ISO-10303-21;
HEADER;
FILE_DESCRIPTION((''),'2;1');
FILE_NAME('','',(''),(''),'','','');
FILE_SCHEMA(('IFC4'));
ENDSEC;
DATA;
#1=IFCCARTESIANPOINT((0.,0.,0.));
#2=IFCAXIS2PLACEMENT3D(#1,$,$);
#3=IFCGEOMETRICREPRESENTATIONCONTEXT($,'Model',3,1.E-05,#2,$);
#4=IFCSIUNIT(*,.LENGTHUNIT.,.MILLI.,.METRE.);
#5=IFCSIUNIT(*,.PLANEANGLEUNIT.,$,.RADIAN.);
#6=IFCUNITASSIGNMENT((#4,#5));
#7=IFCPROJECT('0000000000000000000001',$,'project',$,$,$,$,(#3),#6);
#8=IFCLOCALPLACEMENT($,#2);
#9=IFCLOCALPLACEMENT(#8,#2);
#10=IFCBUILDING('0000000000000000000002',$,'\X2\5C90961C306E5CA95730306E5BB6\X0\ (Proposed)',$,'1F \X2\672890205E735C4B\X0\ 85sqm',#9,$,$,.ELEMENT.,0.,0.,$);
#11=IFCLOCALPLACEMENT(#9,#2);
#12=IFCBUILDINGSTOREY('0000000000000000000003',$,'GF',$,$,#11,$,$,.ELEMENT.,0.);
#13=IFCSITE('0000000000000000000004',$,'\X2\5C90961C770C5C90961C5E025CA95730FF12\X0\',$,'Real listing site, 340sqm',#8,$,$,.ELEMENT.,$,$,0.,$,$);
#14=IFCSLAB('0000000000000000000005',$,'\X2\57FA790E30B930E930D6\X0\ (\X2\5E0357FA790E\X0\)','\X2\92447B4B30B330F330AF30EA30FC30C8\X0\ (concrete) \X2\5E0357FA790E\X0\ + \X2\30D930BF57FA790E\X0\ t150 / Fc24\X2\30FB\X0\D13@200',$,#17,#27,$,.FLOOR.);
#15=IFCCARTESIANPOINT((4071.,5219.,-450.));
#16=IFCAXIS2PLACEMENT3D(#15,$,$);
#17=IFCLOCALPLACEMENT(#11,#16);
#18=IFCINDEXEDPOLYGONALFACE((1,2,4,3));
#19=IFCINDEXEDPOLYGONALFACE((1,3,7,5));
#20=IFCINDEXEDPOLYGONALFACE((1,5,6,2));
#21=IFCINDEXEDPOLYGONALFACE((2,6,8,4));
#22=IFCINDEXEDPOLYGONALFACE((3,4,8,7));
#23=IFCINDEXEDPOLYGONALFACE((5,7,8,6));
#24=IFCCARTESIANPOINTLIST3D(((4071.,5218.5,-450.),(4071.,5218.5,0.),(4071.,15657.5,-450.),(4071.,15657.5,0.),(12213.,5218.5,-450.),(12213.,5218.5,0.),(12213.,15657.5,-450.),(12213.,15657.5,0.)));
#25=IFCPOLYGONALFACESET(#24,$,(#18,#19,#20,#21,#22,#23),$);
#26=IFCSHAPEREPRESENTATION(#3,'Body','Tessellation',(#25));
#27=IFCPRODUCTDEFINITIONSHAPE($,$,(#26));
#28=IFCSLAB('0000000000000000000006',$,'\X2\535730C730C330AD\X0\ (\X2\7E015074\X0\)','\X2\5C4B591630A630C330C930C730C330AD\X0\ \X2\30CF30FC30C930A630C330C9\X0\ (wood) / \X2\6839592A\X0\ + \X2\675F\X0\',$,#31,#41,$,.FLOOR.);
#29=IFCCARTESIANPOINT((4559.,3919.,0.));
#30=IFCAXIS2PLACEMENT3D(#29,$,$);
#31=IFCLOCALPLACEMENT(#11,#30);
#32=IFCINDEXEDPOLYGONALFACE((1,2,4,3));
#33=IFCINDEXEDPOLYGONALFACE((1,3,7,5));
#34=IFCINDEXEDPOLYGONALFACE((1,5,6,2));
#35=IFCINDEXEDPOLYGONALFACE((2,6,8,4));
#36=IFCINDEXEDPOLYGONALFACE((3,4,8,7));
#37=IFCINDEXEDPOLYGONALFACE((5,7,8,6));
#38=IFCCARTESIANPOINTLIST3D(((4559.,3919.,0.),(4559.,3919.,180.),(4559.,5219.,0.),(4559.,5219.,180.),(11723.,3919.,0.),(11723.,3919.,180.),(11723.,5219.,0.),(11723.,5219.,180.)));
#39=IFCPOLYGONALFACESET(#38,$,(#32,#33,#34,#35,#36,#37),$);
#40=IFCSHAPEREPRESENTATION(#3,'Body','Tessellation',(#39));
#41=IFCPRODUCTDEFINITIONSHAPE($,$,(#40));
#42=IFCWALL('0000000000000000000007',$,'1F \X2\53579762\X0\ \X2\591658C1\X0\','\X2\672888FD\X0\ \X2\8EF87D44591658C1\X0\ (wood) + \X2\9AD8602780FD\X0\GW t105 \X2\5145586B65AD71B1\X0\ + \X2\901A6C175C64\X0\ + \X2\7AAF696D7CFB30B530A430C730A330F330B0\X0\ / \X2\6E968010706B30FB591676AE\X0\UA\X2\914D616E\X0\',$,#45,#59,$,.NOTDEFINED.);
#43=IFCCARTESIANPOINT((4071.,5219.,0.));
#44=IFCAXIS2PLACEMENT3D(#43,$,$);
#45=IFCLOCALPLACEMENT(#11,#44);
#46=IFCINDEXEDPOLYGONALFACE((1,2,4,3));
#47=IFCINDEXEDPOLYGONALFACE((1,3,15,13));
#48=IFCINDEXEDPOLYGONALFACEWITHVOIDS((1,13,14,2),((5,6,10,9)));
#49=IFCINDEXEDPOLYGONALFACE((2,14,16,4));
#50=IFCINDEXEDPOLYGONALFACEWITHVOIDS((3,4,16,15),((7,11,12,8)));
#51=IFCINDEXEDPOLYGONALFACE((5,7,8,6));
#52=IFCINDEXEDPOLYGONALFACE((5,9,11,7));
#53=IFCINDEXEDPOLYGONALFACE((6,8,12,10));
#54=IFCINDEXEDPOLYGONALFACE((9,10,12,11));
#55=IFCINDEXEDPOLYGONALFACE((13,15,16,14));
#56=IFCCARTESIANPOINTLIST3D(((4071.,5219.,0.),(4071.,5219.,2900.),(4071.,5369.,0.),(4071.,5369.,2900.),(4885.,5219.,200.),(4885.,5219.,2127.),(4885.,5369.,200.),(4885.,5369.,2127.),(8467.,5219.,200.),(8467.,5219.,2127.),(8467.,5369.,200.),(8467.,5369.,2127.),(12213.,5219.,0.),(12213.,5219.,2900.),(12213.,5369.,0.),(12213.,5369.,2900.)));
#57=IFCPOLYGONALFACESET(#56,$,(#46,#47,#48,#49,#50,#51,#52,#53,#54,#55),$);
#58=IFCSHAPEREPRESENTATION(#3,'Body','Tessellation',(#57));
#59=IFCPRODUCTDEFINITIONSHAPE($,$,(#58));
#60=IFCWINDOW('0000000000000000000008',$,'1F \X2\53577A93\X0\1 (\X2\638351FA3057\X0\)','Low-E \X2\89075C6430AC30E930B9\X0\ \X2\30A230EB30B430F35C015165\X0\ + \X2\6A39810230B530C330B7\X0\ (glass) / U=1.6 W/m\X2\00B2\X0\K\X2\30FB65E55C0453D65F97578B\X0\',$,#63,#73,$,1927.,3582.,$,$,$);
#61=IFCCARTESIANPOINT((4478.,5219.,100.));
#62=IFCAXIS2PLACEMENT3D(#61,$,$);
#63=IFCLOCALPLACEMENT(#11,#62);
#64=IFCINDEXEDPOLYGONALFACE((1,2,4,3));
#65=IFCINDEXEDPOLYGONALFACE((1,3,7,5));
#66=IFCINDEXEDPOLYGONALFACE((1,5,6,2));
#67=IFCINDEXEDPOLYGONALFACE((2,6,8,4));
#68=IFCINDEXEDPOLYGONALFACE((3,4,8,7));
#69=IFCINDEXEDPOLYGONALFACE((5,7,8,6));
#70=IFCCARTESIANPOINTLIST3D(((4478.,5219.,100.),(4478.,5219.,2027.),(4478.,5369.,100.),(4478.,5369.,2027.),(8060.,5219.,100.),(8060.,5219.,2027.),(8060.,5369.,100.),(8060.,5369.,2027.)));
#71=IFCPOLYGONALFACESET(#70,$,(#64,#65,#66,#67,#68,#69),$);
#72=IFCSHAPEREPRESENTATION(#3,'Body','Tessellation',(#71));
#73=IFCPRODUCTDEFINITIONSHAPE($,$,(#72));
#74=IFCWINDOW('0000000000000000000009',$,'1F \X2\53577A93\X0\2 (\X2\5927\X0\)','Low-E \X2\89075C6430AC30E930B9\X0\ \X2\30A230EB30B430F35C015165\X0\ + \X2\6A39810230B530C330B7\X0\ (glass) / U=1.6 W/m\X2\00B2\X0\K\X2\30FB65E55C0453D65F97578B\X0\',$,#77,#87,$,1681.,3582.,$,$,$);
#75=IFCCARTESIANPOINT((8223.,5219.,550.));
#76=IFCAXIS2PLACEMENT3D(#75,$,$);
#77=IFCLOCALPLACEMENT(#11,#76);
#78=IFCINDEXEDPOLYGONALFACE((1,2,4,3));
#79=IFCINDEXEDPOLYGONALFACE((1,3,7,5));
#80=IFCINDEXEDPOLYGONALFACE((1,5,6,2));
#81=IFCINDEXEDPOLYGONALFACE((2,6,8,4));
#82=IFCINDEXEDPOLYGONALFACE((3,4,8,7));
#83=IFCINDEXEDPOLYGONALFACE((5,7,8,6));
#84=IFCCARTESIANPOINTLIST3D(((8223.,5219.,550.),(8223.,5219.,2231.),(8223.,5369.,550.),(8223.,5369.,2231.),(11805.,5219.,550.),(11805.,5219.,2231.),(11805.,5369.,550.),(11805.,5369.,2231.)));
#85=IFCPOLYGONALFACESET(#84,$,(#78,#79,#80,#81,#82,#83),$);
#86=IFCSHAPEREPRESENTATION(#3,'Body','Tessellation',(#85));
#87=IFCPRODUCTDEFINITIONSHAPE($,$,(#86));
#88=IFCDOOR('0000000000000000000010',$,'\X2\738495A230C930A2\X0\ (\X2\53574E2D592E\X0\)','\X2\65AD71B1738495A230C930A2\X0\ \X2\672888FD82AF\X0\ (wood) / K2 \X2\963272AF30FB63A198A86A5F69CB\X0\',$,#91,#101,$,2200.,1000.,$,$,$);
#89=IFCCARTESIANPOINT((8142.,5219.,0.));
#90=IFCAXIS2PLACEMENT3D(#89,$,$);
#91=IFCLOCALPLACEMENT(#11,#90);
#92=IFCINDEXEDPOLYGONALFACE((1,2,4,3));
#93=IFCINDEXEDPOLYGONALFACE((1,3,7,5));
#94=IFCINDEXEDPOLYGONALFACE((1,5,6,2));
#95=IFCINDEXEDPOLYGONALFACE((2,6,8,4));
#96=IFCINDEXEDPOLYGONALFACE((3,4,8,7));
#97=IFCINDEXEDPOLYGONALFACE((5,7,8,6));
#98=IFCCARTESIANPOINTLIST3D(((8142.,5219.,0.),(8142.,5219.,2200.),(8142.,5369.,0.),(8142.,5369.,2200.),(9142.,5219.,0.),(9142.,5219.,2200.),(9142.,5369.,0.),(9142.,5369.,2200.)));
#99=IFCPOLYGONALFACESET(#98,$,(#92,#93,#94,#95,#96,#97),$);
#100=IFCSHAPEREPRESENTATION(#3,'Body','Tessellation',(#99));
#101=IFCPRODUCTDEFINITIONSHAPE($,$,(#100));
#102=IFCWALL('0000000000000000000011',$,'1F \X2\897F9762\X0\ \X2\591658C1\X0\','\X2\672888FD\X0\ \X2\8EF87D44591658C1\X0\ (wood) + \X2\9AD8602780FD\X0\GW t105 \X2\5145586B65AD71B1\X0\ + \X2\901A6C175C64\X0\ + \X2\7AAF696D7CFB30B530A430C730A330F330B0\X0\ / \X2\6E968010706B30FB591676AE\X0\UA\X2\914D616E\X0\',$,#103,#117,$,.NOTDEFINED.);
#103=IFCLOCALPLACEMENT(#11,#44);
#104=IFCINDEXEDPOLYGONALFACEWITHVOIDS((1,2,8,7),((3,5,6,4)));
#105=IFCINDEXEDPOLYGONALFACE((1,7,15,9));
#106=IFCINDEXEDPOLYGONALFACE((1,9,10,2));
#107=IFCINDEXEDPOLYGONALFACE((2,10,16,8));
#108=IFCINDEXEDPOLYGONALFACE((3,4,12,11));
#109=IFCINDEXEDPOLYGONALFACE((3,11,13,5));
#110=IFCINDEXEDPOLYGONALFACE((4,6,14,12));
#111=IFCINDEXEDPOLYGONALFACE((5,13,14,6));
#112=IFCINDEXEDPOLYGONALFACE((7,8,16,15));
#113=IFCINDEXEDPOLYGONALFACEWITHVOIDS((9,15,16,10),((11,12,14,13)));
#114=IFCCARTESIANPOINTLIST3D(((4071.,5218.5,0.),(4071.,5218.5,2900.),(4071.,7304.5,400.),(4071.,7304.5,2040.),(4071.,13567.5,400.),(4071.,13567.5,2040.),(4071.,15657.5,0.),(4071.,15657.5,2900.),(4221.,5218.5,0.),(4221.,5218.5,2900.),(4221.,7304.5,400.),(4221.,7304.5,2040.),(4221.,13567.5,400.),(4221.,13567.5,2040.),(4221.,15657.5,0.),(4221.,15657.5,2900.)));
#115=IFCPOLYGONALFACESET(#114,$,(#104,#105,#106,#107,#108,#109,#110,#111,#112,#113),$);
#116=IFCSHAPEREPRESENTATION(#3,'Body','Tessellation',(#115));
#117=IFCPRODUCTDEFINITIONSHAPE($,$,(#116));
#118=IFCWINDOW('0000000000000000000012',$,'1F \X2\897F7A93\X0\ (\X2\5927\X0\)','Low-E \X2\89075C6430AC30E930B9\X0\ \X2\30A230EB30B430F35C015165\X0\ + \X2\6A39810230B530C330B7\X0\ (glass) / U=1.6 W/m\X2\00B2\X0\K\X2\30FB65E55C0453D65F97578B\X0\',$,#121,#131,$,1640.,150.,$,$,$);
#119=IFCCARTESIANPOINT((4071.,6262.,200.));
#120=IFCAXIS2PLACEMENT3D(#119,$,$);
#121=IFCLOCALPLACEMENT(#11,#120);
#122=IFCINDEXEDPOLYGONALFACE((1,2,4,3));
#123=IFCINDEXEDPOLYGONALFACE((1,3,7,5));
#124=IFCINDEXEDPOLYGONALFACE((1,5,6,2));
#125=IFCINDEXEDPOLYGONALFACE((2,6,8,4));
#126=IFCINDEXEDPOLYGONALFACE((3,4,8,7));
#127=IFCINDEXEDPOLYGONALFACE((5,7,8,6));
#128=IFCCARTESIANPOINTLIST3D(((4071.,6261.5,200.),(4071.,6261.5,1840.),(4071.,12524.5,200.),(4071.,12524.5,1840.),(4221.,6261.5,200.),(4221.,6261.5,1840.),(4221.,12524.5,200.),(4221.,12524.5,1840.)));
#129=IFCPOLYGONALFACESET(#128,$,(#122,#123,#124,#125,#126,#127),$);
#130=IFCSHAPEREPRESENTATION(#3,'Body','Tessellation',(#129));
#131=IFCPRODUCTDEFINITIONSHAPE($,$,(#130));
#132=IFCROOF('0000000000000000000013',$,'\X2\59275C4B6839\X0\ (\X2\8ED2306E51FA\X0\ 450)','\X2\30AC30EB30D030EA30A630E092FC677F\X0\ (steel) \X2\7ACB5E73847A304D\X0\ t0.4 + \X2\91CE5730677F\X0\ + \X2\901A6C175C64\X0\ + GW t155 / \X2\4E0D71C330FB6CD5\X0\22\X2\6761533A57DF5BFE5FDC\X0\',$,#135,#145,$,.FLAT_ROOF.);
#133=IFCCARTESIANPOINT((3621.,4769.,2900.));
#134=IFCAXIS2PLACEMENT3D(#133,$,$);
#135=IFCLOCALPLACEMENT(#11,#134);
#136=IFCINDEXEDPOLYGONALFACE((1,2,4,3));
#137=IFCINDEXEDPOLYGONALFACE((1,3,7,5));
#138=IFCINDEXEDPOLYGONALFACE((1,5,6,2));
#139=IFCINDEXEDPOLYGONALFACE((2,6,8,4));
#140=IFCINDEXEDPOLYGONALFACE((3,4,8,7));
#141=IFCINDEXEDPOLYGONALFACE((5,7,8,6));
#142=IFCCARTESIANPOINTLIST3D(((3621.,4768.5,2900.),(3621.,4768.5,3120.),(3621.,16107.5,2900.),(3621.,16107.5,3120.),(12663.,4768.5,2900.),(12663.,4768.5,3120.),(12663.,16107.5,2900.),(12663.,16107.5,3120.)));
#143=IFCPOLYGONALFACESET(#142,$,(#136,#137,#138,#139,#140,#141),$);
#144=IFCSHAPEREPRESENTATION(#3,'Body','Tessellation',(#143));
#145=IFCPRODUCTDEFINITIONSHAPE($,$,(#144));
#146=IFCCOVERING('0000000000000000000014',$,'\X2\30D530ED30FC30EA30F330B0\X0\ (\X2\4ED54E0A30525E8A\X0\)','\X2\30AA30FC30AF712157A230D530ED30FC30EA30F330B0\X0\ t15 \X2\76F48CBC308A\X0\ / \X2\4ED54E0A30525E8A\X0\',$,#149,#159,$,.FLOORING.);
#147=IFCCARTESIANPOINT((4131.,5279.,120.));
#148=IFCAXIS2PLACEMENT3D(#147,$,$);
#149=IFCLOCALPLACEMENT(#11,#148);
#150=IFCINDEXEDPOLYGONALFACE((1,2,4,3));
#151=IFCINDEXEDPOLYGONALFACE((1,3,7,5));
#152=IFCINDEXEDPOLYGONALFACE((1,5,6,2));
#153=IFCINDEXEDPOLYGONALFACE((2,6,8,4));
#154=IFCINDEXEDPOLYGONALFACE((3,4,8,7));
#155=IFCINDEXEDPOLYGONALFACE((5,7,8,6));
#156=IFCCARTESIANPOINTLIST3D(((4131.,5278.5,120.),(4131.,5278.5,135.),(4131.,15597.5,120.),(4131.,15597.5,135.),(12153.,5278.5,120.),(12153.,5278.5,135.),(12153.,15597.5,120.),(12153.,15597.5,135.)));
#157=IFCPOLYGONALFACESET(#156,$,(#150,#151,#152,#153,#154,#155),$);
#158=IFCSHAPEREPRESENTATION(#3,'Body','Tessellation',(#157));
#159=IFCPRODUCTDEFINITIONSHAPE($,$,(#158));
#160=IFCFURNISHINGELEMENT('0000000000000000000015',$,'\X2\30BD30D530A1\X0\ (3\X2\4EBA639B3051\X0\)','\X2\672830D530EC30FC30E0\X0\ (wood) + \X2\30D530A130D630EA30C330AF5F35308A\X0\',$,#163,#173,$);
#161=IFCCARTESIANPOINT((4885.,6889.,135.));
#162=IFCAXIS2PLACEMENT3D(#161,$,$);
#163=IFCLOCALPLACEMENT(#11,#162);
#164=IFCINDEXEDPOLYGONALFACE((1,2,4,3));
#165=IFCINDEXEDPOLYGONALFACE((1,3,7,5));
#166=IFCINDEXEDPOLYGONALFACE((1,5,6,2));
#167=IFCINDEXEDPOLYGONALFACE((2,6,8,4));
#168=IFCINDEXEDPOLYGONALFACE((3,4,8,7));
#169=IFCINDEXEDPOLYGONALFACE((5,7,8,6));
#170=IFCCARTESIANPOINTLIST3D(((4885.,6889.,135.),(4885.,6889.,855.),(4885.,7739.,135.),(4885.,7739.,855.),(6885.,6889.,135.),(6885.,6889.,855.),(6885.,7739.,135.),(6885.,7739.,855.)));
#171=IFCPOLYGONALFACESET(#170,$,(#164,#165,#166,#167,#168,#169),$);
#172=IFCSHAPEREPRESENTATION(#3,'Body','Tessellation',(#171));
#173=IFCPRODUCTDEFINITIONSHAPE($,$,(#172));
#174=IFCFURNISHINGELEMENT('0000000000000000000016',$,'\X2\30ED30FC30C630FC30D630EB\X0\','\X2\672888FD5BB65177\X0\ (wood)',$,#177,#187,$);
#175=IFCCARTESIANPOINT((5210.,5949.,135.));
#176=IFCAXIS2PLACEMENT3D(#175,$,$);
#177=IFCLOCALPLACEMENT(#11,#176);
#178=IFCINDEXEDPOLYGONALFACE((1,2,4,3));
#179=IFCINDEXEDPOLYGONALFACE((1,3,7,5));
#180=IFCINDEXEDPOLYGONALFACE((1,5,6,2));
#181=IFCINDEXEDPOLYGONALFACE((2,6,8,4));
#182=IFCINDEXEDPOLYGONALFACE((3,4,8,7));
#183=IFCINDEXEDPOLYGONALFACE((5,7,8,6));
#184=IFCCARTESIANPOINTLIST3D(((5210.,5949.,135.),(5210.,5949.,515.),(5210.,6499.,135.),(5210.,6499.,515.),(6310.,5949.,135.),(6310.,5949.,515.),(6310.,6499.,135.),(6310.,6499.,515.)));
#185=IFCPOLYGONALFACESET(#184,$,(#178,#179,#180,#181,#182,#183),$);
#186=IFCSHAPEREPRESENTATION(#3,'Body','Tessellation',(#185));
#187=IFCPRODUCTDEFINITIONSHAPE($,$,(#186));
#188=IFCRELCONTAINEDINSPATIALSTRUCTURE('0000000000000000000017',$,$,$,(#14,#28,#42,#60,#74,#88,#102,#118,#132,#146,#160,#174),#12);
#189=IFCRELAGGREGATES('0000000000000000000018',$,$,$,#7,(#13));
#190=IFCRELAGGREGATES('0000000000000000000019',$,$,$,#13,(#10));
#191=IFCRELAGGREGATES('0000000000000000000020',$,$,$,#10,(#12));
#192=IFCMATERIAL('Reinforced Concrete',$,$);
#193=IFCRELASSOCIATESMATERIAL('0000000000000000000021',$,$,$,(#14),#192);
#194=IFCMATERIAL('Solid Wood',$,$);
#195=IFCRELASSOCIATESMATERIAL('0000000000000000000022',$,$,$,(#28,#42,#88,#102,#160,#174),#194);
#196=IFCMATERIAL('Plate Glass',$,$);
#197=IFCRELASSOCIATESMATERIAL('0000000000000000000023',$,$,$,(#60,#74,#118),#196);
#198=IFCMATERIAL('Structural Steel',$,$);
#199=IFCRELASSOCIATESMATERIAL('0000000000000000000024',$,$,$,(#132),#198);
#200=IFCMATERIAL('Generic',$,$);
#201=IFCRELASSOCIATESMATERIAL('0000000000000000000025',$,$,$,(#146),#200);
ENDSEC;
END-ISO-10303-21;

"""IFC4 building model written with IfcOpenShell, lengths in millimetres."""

from ifc_helpers import new_model, si_unit, frame, frame_2d, origin, place, context, project, spatial, rectangle, extrude, material, element, fill, save


model = new_model("IFC4")

# Units and contexts
model_context = context("Model", 3, precision=1e-05, world=origin())
ifc_project = project(units=[si_unit("LENGTHUNIT", "METRE", prefix="MILLI"), si_unit("PLANEANGLEUNIT", "RADIAN")], contexts=[model_context])

# Site, building, storey
site_placement = place(None, origin())
site = spatial("IfcSite", under=ifc_project, at=site_placement, Name="岐阜県岐阜市岩地２", ObjectType="Real listing site, 340sqm", CompositionType="ELEMENT", RefElevation=0.0)
building_placement = place(site_placement, origin())
building = spatial("IfcBuilding", under=site, at=building_placement, Name="岐阜の岩地の家 (Proposed)", ObjectType="1F 木造平屋 85sqm", CompositionType="ELEMENT", ElevationOfRefHeight=0.0, ElevationOfTerrain=0.0)
storey_placement = place(building_placement, origin())
storey = spatial("IfcBuildingStorey", under=building, at=storey_placement, Name="GF", CompositionType="ELEMENT", Elevation=0.0)

# Slabs
ifc_material_1 = material(Name="Reinforced Concrete")
slab_1_placement = place(storey_placement, frame((4071.0, 5219.0, -450.0)))
element("IfcSlab", 1, at=slab_1_placement, inside=storey, material=ifc_material_1, Name="基礎スラブ (布基礎)", Description="鉄筋コンクリート (concrete) 布基礎 + ベタ基礎 t150 / Fc24・D13@200", PredefinedType="FLOOR", context=model_context, shape_type="SweptSolid", body=[
    extrude(rectangle(XDim=8142.0, YDim=10439.0, at=frame_2d((4071.0, 5219.0))), frame((4071.0, 5219.0, -450.0)), (0.0, 0.0, 1.0), 450.0),
])
ifc_material_2 = material(Name="Solid Wood")
slab_2_placement = place(storey_placement, frame((4559.0, 3919.0, 0.0)))
element("IfcSlab", 2, at=slab_2_placement, inside=storey, material=ifc_material_2, Name="南デッキ (縁側)", Description="屋外ウッドデッキ ハードウッド (wood) / 根太 + 束", PredefinedType="FLOOR", context=model_context, shape_type="SweptSolid", body=[
    extrude(rectangle(XDim=7164.0, YDim=1300.0, at=frame_2d((3582.0, 650.0))), frame((4559.0, 3919.0, 0.0)), (0.0, 0.0, 1.0), 180.0),
])

# Wall, openings, windows, door
wall_1_placement = place(storey_placement, frame((4071.0, 5219.0, 0.0)))
wall_1 = element("IfcWall", 3, at=wall_1_placement, inside=storey, material=ifc_material_2, Name="1F 南面 外壁", Description="木製 軸組外壁 (wood) + 高性能GW t105 充填断熱 + 通気層 + 窯業系サイディング / 準耐火・外皮UA配慮", PredefinedType="NOTDEFINED", context=model_context, shape_type="SweptSolid", body=[
    extrude(rectangle(XDim=8142.0, YDim=150.0, at=frame_2d((4071.0, 75.0))), frame((4071.0, 5219.0, 0.0)), (0.0, 0.0, 1.0), 2900.0),
])
opening_1_placement = place(storey_placement, frame((4478.0, 5219.0, 100.0)))
opening_1 = element("IfcOpeningElement", 4, at=opening_1_placement, cuts=wall_1, PredefinedType="NOTDEFINED", context=model_context, shape_type="SweptSolid", body=[
    extrude(rectangle(XDim=3582.0, YDim=150.0, at=frame_2d((1791.0, 75.0))), frame((4478.0, 5219.0, 100.0)), (0.0, 0.0, 1.0), 1927.0),
])
opening_2_placement = place(storey_placement, frame((8223.0, 5219.0, 550.0)))
opening_2 = element("IfcOpeningElement", 5, at=opening_2_placement, cuts=wall_1, PredefinedType="NOTDEFINED", context=model_context, shape_type="SweptSolid", body=[
    extrude(rectangle(XDim=3582.0, YDim=150.0, at=frame_2d((1791.0, 75.0))), frame((8223.0, 5219.0, 550.0)), (0.0, 0.0, 1.0), 1681.0),
])
opening_3_placement = place(storey_placement, frame((8142.0, 5219.0, 0.0)))
opening_3 = element("IfcOpeningElement", 6, at=opening_3_placement, cuts=wall_1, PredefinedType="NOTDEFINED", context=model_context, shape_type="SweptSolid", body=[
    extrude(rectangle(XDim=1000.0, YDim=150.0, at=frame_2d((500.0, 75.0))), frame((8142.0, 5219.0, 0.0)), (0.0, 0.0, 1.0), 2200.0),
])
ifc_material_3 = material(Name="Plate Glass")
window_1_placement = place(storey_placement, frame((4478.0, 5219.0, 100.0)))
window_1 = element("IfcWindow", 7, at=window_1_placement, inside=storey, material=ifc_material_3, Name="1F 南窓1 (掃出し)", Description="Low-E 複層ガラス アルゴン封入 + 樹脂サッシ (glass) / U=1.6 W/m²K・日射取得型", OverallHeight=1927.0, OverallWidth=3582.0, context=model_context, shape_type="SweptSolid", body=[
    extrude(rectangle(XDim=3582.0, YDim=150.0, at=frame_2d((1791.0, 75.0))), frame((4478.0, 5219.0, 100.0)), (0.0, 0.0, 1.0), 1927.0),
])
fill(opening_1, window_1)
window_2_placement = place(storey_placement, frame((8223.0, 5219.0, 550.0)))
window_2 = element("IfcWindow", 8, at=window_2_placement, inside=storey, material=ifc_material_3, Name="1F 南窓2 (大)", Description="Low-E 複層ガラス アルゴン封入 + 樹脂サッシ (glass) / U=1.6 W/m²K・日射取得型", OverallHeight=1681.0, OverallWidth=3582.0, context=model_context, shape_type="SweptSolid", body=[
    extrude(rectangle(XDim=3582.0, YDim=150.0, at=frame_2d((1791.0, 75.0))), frame((8223.0, 5219.0, 550.0)), (0.0, 0.0, 1.0), 1681.0),
])
fill(opening_2, window_2)
door_placement = place(storey_placement, frame((8142.0, 5219.0, 0.0)))
door = element("IfcDoor", 9, at=door_placement, inside=storey, material=ifc_material_2, Name="玄関ドア (南中央)", Description="断熱玄関ドア 木製芯 (wood) / K2 防犯・採風機構", OverallHeight=2200.0, OverallWidth=1000.0, context=model_context, shape_type="SweptSolid", body=[
    extrude(rectangle(XDim=1000.0, YDim=150.0, at=frame_2d((500.0, 75.0))), frame((8142.0, 5219.0, 0.0)), (0.0, 0.0, 1.0), 2200.0),
])
fill(opening_3, door)

# Wall, opening, window
wall_2_placement = place(storey_placement, frame((4071.0, 5219.0, 0.0)))
wall_2 = element("IfcWall", 10, at=wall_2_placement, inside=storey, material=ifc_material_2, Name="1F 西面 外壁", Description="木製 軸組外壁 (wood) + 高性能GW t105 充填断熱 + 通気層 + 窯業系サイディング / 準耐火・外皮UA配慮", PredefinedType="NOTDEFINED", context=model_context, shape_type="SweptSolid", body=[
    extrude(rectangle(XDim=150.0, YDim=10439.0, at=frame_2d((75.0, 5219.0))), frame((4071.0, 5219.0, 0.0)), (0.0, 0.0, 1.0), 2900.0),
])
opening_4_placement = place(storey_placement, frame((4071.0, 6262.0, 200.0)))
opening_4 = element("IfcOpeningElement", 11, at=opening_4_placement, cuts=wall_2, PredefinedType="NOTDEFINED", context=model_context, shape_type="SweptSolid", body=[
    extrude(rectangle(XDim=150.0, YDim=6263.0, at=frame_2d((75.0, 3131.0))), frame((4071.0, 6262.0, 200.0)), (0.0, 0.0, 1.0), 1640.0),
])
window_3_placement = place(storey_placement, frame((4071.0, 6262.0, 200.0)))
window_3 = element("IfcWindow", 12, at=window_3_placement, inside=storey, material=ifc_material_3, Name="1F 西窓 (大)", Description="Low-E 複層ガラス アルゴン封入 + 樹脂サッシ (glass) / U=1.6 W/m²K・日射取得型", OverallHeight=1640.0, OverallWidth=150.0, context=model_context, shape_type="SweptSolid", body=[
    extrude(rectangle(XDim=150.0, YDim=6263.0, at=frame_2d((75.0, 3131.0))), frame((4071.0, 6262.0, 200.0)), (0.0, 0.0, 1.0), 1640.0),
])
fill(opening_4, window_3)

# Roof
ifc_material_4 = material(Name="Structural Steel")
roof_placement = place(storey_placement, frame((3621.0, 4769.0, 2900.0)))
element("IfcRoof", 13, at=roof_placement, inside=storey, material=ifc_material_4, Name="大屋根 (軒の出 450)", Description="ガルバリウム鋼板 (steel) 立平葺き t0.4 + 野地板 + 通気層 + GW t155 / 不燃・法22条区域対応", PredefinedType="FLAT_ROOF", context=model_context, shape_type="SweptSolid", body=[
    extrude(rectangle(XDim=9042.0, YDim=11339.0, at=frame_2d((4521.0, 5669.0))), frame((3621.0, 4769.0, 2900.0)), (0.0, 0.0, 1.0), 220.0),
])

# Covering
ifc_material_5 = material(Name="Generic")
covering_placement = place(storey_placement, frame((4131.0, 5279.0, 120.0)))
element("IfcCovering", 14, at=covering_placement, inside=storey, material=ifc_material_5, Name="フローリング (仕上げ床)", Description="オーク無垢フローリング t15 直貼り / 仕上げ床", PredefinedType="FLOORING", context=model_context, shape_type="SweptSolid", body=[
    extrude(rectangle(XDim=8022.0, YDim=10319.0, at=frame_2d((4011.0, 5159.0))), frame((4131.0, 5279.0, 120.0)), (0.0, 0.0, 1.0), 15.0),
])

# Furnishing elements
furnishing_1_placement = place(storey_placement, frame((4885.0, 6889.0, 135.0)))
element("IfcFurnishingElement", 15, at=furnishing_1_placement, inside=storey, material=ifc_material_2, Name="ソファ (3人掛け)", Description="木フレーム (wood) + ファブリック張り", context=model_context, shape_type="SweptSolid", body=[
    extrude(rectangle(XDim=2000.0, YDim=850.0, at=frame_2d((1000.0, 425.0))), frame((4885.0, 6889.0, 135.0)), (0.0, 0.0, 1.0), 720.0),
])
furnishing_2_placement = place(storey_placement, frame((5210.0, 5949.0, 135.0)))
element("IfcFurnishingElement", 16, at=furnishing_2_placement, inside=storey, material=ifc_material_2, Name="ローテーブル", Description="木製家具 (wood)", context=model_context, shape_type="SweptSolid", body=[
    extrude(rectangle(XDim=1100.0, YDim=550.0, at=frame_2d((550.0, 275.0))), frame((5210.0, 5949.0, 135.0)), (0.0, 0.0, 1.0), 380.0),
])

save(model, "model.ifc")
